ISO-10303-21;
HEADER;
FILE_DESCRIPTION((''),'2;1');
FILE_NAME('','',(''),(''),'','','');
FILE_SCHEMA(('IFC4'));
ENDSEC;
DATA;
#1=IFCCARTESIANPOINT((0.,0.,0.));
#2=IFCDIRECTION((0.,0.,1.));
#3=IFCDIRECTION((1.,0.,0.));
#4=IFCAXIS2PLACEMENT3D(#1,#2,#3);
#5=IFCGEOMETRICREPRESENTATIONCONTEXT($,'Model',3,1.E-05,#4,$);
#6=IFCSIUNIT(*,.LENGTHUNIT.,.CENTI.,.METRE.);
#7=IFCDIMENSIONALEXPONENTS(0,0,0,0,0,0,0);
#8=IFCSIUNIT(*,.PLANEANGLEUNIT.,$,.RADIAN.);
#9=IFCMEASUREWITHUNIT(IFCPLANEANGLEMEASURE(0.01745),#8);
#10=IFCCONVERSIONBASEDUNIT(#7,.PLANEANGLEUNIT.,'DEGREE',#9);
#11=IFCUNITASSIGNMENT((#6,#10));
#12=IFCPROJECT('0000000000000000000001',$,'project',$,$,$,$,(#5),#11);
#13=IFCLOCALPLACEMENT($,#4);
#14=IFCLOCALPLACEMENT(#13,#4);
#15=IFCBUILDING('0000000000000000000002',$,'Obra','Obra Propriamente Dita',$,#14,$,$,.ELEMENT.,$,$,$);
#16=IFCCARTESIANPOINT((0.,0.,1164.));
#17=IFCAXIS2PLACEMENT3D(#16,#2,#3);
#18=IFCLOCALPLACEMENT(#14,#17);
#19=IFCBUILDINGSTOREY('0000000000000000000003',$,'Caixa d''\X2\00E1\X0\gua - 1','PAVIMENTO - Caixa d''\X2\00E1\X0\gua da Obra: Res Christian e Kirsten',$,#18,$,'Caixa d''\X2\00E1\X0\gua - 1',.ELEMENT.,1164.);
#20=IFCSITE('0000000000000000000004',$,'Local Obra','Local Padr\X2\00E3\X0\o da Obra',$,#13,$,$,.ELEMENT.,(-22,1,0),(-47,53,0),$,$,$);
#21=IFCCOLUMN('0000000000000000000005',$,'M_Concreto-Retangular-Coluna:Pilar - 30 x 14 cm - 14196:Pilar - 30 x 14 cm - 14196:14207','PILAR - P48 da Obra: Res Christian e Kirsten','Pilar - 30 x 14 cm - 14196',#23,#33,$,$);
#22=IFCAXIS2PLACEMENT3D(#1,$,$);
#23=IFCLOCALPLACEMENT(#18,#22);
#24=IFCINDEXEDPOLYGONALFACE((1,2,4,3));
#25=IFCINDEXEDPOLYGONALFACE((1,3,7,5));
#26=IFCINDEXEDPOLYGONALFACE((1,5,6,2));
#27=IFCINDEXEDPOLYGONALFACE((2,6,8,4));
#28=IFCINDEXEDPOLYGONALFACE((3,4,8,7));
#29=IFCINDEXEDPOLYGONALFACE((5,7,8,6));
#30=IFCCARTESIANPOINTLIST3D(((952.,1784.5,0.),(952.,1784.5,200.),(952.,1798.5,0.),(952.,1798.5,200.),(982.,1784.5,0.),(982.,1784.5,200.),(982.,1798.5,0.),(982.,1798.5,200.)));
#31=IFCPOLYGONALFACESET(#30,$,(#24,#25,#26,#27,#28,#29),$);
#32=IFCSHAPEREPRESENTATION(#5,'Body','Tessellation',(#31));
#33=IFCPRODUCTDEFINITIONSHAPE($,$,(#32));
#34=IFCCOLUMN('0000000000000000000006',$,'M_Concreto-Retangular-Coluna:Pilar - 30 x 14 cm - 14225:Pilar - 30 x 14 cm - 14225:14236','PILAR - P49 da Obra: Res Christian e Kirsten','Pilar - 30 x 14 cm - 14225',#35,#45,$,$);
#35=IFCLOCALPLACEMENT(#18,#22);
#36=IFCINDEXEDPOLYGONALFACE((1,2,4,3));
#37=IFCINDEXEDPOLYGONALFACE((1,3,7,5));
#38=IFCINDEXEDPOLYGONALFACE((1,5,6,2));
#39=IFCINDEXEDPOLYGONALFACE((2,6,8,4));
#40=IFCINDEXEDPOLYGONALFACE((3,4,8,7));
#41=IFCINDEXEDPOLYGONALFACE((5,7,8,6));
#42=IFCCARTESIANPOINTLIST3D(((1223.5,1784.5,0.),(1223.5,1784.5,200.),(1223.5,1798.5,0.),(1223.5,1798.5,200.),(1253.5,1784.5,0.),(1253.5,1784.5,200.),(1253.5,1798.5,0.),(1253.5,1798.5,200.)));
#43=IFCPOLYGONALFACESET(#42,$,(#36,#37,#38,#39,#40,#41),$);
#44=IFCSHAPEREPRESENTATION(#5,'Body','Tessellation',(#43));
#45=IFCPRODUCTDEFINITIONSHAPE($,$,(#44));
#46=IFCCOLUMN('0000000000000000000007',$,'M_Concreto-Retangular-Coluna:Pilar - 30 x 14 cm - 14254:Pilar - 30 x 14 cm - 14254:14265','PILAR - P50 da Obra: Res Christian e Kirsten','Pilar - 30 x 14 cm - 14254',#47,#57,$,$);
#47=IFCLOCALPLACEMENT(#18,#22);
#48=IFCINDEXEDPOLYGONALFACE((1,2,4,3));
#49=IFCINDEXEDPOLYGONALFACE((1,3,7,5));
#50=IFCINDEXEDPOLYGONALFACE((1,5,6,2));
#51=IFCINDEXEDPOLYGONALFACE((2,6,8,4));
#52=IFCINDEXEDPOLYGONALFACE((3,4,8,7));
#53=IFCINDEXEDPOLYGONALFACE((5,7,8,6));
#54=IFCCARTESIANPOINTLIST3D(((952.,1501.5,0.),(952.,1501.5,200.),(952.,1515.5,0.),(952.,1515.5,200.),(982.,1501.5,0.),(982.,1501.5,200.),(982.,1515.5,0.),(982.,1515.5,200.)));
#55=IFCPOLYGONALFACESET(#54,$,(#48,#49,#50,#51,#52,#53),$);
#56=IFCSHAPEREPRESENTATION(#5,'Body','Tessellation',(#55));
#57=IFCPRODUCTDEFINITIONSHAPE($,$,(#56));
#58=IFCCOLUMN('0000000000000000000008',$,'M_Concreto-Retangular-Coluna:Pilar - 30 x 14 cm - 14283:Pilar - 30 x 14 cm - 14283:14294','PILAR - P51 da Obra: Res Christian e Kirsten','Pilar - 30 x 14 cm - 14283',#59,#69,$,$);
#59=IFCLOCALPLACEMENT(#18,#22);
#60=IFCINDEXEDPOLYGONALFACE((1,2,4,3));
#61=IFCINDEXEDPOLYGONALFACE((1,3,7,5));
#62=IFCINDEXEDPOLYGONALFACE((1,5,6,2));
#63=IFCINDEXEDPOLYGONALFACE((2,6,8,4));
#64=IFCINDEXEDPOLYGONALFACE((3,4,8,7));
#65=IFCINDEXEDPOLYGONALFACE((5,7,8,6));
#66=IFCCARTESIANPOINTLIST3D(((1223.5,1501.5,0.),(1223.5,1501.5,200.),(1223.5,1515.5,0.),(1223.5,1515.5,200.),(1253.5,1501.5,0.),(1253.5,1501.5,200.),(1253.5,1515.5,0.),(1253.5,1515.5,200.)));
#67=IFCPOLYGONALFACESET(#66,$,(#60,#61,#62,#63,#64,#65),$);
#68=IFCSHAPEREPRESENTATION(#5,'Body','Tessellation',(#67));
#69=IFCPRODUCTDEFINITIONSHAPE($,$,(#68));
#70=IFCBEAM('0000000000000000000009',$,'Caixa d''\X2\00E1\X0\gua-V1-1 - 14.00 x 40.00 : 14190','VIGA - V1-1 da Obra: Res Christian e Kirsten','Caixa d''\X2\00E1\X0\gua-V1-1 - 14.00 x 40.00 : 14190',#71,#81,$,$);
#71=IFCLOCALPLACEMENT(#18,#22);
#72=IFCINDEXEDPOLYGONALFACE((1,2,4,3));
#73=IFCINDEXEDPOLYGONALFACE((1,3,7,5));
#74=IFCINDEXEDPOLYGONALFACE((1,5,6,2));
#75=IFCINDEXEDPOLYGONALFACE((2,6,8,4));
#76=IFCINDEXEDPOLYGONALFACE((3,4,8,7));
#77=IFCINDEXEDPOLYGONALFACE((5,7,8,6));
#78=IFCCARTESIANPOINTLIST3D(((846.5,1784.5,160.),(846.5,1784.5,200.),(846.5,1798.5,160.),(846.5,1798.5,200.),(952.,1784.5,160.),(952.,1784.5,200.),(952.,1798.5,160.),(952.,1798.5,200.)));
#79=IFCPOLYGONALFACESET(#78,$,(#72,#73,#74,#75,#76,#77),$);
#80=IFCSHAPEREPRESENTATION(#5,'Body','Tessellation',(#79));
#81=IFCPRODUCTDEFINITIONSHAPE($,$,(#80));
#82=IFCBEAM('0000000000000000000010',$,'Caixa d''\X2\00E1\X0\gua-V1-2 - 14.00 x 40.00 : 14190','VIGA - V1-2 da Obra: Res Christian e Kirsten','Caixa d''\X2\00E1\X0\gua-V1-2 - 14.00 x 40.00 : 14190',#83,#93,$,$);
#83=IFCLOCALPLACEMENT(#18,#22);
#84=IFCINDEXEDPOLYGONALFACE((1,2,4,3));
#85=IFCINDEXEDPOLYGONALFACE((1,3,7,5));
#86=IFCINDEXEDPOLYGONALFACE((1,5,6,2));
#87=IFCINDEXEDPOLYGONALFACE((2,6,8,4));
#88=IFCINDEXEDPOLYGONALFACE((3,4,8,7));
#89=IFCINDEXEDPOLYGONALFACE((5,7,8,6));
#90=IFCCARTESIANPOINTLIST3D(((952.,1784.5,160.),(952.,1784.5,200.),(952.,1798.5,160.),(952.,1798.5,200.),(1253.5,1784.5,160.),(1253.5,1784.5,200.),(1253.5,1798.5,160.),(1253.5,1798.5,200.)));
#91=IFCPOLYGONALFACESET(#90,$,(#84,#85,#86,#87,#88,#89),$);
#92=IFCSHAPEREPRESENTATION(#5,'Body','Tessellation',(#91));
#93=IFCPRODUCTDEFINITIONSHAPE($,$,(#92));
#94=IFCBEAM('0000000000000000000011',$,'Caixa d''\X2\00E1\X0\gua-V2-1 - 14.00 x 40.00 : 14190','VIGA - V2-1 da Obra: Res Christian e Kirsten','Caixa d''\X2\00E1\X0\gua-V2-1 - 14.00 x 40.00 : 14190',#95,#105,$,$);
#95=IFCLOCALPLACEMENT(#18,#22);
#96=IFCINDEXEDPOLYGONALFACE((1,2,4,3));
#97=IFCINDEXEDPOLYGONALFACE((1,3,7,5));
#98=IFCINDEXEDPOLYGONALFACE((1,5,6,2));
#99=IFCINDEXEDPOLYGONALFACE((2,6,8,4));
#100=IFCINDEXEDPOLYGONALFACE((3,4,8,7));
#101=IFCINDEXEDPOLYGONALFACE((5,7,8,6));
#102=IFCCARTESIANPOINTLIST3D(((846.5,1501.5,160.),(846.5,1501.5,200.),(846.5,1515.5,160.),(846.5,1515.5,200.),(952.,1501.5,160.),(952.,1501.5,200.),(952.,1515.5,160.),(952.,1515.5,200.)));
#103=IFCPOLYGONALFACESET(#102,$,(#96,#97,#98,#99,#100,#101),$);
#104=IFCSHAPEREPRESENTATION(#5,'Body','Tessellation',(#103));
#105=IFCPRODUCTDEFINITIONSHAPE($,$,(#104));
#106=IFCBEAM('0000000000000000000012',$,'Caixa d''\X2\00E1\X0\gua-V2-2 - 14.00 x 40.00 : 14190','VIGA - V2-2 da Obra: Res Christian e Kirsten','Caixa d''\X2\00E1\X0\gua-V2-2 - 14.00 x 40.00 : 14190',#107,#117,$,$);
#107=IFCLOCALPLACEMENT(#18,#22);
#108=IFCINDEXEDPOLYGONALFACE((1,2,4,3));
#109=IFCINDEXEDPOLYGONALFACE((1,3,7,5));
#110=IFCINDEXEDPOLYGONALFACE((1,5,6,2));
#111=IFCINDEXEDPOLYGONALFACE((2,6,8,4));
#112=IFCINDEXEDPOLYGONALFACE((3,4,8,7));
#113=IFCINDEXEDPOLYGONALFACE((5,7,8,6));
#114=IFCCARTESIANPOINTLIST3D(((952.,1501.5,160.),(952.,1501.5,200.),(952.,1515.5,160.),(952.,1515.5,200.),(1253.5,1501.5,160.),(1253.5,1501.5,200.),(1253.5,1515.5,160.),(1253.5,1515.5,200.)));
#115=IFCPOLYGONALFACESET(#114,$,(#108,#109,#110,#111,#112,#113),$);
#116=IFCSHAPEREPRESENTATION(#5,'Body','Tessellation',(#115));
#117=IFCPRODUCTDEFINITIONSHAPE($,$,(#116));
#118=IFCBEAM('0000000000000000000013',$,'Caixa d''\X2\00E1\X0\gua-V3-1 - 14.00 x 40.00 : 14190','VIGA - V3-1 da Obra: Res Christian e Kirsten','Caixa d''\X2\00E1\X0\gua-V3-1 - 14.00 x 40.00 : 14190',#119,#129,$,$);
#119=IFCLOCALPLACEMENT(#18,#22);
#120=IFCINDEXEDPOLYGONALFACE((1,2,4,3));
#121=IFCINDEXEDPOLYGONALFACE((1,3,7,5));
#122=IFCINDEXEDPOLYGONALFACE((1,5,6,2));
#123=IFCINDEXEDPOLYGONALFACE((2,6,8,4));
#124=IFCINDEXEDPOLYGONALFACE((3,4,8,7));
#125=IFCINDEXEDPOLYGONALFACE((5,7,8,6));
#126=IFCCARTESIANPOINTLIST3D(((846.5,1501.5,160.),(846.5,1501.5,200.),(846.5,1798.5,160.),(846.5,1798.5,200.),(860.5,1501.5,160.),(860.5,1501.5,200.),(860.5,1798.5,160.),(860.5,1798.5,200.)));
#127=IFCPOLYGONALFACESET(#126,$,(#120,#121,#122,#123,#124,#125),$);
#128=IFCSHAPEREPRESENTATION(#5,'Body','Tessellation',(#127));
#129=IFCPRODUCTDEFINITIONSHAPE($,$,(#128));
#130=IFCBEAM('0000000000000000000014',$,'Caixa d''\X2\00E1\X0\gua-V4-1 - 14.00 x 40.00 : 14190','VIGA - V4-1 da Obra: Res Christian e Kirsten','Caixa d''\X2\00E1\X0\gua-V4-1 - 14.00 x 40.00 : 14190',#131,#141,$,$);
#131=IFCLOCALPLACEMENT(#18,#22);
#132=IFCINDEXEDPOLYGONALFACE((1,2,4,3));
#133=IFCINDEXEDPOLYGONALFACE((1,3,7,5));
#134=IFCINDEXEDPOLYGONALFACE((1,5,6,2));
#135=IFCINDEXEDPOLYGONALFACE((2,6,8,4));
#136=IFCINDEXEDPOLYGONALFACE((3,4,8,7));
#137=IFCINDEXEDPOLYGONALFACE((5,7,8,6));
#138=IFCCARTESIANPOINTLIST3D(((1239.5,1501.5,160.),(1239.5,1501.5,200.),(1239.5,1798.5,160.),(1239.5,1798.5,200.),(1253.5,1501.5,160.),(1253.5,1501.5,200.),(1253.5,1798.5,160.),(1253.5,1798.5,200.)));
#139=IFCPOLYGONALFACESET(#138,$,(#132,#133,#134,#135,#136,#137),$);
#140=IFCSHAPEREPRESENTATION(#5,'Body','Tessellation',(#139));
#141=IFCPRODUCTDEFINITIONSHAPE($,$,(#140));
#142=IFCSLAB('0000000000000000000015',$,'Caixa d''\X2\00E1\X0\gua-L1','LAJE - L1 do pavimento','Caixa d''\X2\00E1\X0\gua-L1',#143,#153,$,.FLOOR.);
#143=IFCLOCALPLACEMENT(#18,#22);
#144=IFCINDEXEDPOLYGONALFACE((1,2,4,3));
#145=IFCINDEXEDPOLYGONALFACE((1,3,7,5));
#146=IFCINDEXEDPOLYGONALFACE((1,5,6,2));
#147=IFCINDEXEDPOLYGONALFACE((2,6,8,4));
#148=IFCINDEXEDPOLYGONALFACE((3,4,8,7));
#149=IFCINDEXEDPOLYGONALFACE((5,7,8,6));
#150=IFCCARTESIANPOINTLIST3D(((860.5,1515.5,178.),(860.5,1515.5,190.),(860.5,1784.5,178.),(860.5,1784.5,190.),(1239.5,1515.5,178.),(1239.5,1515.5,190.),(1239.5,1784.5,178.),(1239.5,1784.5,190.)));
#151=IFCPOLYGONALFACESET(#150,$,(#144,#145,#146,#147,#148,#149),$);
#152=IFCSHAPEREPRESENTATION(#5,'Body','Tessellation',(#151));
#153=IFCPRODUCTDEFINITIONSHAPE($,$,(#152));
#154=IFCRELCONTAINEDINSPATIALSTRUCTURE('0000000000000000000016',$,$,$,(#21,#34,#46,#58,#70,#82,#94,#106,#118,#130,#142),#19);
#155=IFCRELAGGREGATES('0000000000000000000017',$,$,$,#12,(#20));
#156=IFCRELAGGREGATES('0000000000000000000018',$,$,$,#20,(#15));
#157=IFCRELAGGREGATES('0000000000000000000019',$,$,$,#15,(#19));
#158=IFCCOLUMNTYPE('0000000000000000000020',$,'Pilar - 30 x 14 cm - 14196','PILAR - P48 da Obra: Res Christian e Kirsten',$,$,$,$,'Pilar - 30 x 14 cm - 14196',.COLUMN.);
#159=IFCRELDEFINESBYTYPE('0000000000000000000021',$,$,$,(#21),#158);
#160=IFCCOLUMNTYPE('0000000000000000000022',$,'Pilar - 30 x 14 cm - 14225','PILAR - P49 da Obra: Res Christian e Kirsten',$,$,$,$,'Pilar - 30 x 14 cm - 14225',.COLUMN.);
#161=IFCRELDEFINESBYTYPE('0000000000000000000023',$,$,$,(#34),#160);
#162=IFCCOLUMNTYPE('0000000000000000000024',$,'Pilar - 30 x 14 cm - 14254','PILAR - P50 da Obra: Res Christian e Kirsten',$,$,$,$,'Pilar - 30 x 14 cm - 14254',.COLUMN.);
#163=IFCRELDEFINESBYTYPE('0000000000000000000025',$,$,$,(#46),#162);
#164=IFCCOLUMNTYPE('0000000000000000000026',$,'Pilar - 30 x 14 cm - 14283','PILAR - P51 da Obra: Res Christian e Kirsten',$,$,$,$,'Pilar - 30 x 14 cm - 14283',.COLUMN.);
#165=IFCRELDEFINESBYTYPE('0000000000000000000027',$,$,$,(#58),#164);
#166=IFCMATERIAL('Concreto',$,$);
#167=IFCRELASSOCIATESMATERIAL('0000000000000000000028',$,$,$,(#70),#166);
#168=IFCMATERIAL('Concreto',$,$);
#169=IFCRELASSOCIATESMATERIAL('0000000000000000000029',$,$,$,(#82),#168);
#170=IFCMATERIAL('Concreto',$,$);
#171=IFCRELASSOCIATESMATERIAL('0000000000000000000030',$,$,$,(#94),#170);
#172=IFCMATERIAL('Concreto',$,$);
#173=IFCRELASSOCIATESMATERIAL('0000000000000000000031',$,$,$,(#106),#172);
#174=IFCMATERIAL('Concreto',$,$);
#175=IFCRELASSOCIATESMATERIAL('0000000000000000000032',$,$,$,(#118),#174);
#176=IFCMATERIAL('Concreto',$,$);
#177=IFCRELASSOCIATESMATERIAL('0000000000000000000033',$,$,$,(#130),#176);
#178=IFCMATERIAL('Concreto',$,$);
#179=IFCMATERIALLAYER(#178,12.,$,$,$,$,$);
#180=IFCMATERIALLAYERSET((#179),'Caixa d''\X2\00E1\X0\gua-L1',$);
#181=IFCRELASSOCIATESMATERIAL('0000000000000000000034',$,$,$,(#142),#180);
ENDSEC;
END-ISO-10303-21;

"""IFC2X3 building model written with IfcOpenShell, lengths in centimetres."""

from ifc_helpers import new_model, entity, si_unit, converted_unit, frame, origin, origin_with_axes, origin_2d_with_axis, place, context, project, spatial, polyline, rectangle, outline, extrude, source, transform, mapped, material, layer, layer_set, layer_usage, type_object, type_shapes, element, save


model = new_model("IFC2X3")

# Units and contexts
model_context = context("Model", 3, precision=1e-05, world=origin_with_axes())
ifc_project = project(units=[si_unit("LENGTHUNIT", "METRE", prefix="CENTI"), converted_unit("PLANEANGLEUNIT", "DEGREE", entity("IfcPlaneAngleMeasure", 0.01745), si_unit("PLANEANGLEUNIT", "RADIAN"), dimensions=[0, 0, 0, 0, 0, 0, 0])], contexts=[model_context])

# Site, building, storey
site_placement = place(None, origin_with_axes())
site = spatial("IfcSite", under=ifc_project, at=site_placement, Name="Local Obra", Description="Local Padrão da Obra", CompositionType="ELEMENT", RefLatitude=(-22, 1, 0), RefLongitude=(-47, 53, 0))
building_placement = place(site_placement, origin_with_axes())
building = spatial("IfcBuilding", under=site, at=building_placement, Name="Obra", Description="Obra Propriamente Dita", CompositionType="ELEMENT")
storey_placement = place(building_placement, frame((0.0, 0.0, 1164.0), z_axis=(0.0, 0.0, 1.0), x_axis=(1.0, 0.0, 0.0)))
storey = spatial("IfcBuildingStorey", under=building, at=storey_placement, Name="Caixa d'água - 1", Description="PAVIMENTO - Caixa d'água da Obra: Res Christian e Kirsten", LongName="Caixa d'água - 1", CompositionType="ELEMENT", Elevation=1164.0)

# Columns
column_type_1 = type_object("IfcColumnType", Name="Pilar - 30 x 14 cm - 14196", Description="PILAR - P48 da Obra: Res Christian e Kirsten", ElementType="Pilar - 30 x 14 cm - 14196", PredefinedType="COLUMN")
shared_shape_1 = source(origin(), model_context, "Body", "SweptSolid", [
    extrude(rectangle(XDim=30.0, YDim=14.0, at=origin_2d_with_axis()), origin(), (0.0, 0.0, 1.0), 200.0),
])
type_shapes(column_type_1, [shared_shape_1])
column_1_placement = place(storey_placement, frame((967.0, 1791.5, 0.0), z_axis=(0.0, 0.0, 1.0), x_axis=(1.0, 0.0, 0.0)))
element("IfcColumn", 1, at=column_1_placement, inside=storey, type_object=column_type_1, Name="M_Concreto-Retangular-Coluna:Pilar - 30 x 14 cm - 14196:Pilar - 30 x 14 cm - 14196:14207", Description="PILAR - P48 da Obra: Res Christian e Kirsten", ObjectType="Pilar - 30 x 14 cm - 14196", context=model_context, shape_type="MappedRepresentation", body=[
    mapped(shared_shape_1, transform((0.0, 0.0, 0.0), scale=1.0)),
])
column_type_2 = type_object("IfcColumnType", Name="Pilar - 30 x 14 cm - 14225", Description="PILAR - P49 da Obra: Res Christian e Kirsten", ElementType="Pilar - 30 x 14 cm - 14225", PredefinedType="COLUMN")
shared_shape_2 = source(origin(), model_context, "Body", "SweptSolid", [
    extrude(rectangle(XDim=30.0, YDim=14.0, at=origin_2d_with_axis()), origin(), (0.0, 0.0, 1.0), 200.0),
])
type_shapes(column_type_2, [shared_shape_2])
column_2_placement = place(storey_placement, frame((1238.5, 1791.5, 0.0), z_axis=(0.0, 0.0, 1.0), x_axis=(1.0, 0.0, 0.0)))
element("IfcColumn", 2, at=column_2_placement, inside=storey, type_object=column_type_2, Name="M_Concreto-Retangular-Coluna:Pilar - 30 x 14 cm - 14225:Pilar - 30 x 14 cm - 14225:14236", Description="PILAR - P49 da Obra: Res Christian e Kirsten", ObjectType="Pilar - 30 x 14 cm - 14225", context=model_context, shape_type="MappedRepresentation", body=[
    mapped(shared_shape_2, transform((0.0, 0.0, 0.0), scale=1.0)),
])
column_type_3 = type_object("IfcColumnType", Name="Pilar - 30 x 14 cm - 14254", Description="PILAR - P50 da Obra: Res Christian e Kirsten", ElementType="Pilar - 30 x 14 cm - 14254", PredefinedType="COLUMN")
shared_shape_3 = source(origin(), model_context, "Body", "SweptSolid", [
    extrude(rectangle(XDim=30.0, YDim=14.0, at=origin_2d_with_axis()), origin(), (0.0, 0.0, 1.0), 200.0),
])
type_shapes(column_type_3, [shared_shape_3])
column_3_placement = place(storey_placement, frame((967.0, 1508.5, 0.0), z_axis=(0.0, 0.0, 1.0), x_axis=(1.0, 0.0, 0.0)))
element("IfcColumn", 3, at=column_3_placement, inside=storey, type_object=column_type_3, Name="M_Concreto-Retangular-Coluna:Pilar - 30 x 14 cm - 14254:Pilar - 30 x 14 cm - 14254:14265", Description="PILAR - P50 da Obra: Res Christian e Kirsten", ObjectType="Pilar - 30 x 14 cm - 14254", context=model_context, shape_type="MappedRepresentation", body=[
    mapped(shared_shape_3, transform((0.0, 0.0, 0.0), scale=1.0)),
])
column_type_4 = type_object("IfcColumnType", Name="Pilar - 30 x 14 cm - 14283", Description="PILAR - P51 da Obra: Res Christian e Kirsten", ElementType="Pilar - 30 x 14 cm - 14283", PredefinedType="COLUMN")
shared_shape_4 = source(origin(), model_context, "Body", "SweptSolid", [
    extrude(rectangle(XDim=30.0, YDim=14.0, at=origin_2d_with_axis()), origin(), (0.0, 0.0, 1.0), 200.0),
])
type_shapes(column_type_4, [shared_shape_4])
column_4_placement = place(storey_placement, frame((1238.5, 1508.5, 0.0), z_axis=(0.0, 0.0, 1.0), x_axis=(1.0, 0.0, 0.0)))
element("IfcColumn", 4, at=column_4_placement, inside=storey, type_object=column_type_4, Name="M_Concreto-Retangular-Coluna:Pilar - 30 x 14 cm - 14283:Pilar - 30 x 14 cm - 14283:14294", Description="PILAR - P51 da Obra: Res Christian e Kirsten", ObjectType="Pilar - 30 x 14 cm - 14283", context=model_context, shape_type="MappedRepresentation", body=[
    mapped(shared_shape_4, transform((0.0, 0.0, 0.0), scale=1.0)),
])

# Beams
ifc_material_1 = material(Name="Concreto")
beam_1_placement = place(storey_placement, frame((846.5, 1798.5, 200.0), z_axis=(1.0, 0.0, 0.0), x_axis=(0.0, -1.0, 0.0)))
element("IfcBeam", 5, at=beam_1_placement, inside=storey, material=ifc_material_1, Name="Caixa d'água-V1-1 - 14.00 x 40.00 : 14190", Description="VIGA - V1-1 da Obra: Res Christian e Kirsten", ObjectType="Caixa d'água-V1-1 - 14.00 x 40.00 : 14190", context=model_context, shape_type="SweptSolid", body=[
    extrude(outline(polyline([(0.0, 0.0), (14.0, 0.0), (14.0, 40.0), (0.0, 40.0), (0.0, 0.0)])), origin_with_axes(), (0.0, 0.0, 1.0), 105.5),
])
ifc_material_2 = material(Name="Concreto")
beam_2_placement = place(storey_placement, frame((952.0, 1798.5, 200.0), z_axis=(1.0, 0.0, 0.0), x_axis=(0.0, -1.0, 0.0)))
element("IfcBeam", 6, at=beam_2_placement, inside=storey, material=ifc_material_2, Name="Caixa d'água-V1-2 - 14.00 x 40.00 : 14190", Description="VIGA - V1-2 da Obra: Res Christian e Kirsten", ObjectType="Caixa d'água-V1-2 - 14.00 x 40.00 : 14190", context=model_context, shape_type="SweptSolid", body=[
    extrude(outline(polyline([(0.0, 0.0), (14.0, 0.0), (14.0, 40.0), (0.0, 40.0), (0.0, 0.0)])), origin_with_axes(), (0.0, 0.0, 1.0), 301.5),
])
ifc_material_3 = material(Name="Concreto")
beam_3_placement = place(storey_placement, frame((846.5, 1501.5, 200.0), z_axis=(1.0, 0.0, 0.0), x_axis=(0.0, -1.0, 0.0)))
element("IfcBeam", 7, at=beam_3_placement, inside=storey, material=ifc_material_3, Name="Caixa d'água-V2-1 - 14.00 x 40.00 : 14190", Description="VIGA - V2-1 da Obra: Res Christian e Kirsten", ObjectType="Caixa d'água-V2-1 - 14.00 x 40.00 : 14190", context=model_context, shape_type="SweptSolid", body=[
    extrude(outline(polyline([(-14.0, 0.0), (0.0, 0.0), (0.0, 40.0), (-14.0, 40.0), (-14.0, 0.0)])), origin_with_axes(), (0.0, 0.0, 1.0), 105.5),
])
ifc_material_4 = material(Name="Concreto")
beam_4_placement = place(storey_placement, frame((952.0, 1501.5, 200.0), z_axis=(1.0, 0.0, 0.0), x_axis=(0.0, -1.0, 0.0)))
element("IfcBeam", 8, at=beam_4_placement, inside=storey, material=ifc_material_4, Name="Caixa d'água-V2-2 - 14.00 x 40.00 : 14190", Description="VIGA - V2-2 da Obra: Res Christian e Kirsten", ObjectType="Caixa d'água-V2-2 - 14.00 x 40.00 : 14190", context=model_context, shape_type="SweptSolid", body=[
    extrude(outline(polyline([(-14.0, 0.0), (0.0, 0.0), (0.0, 40.0), (-14.0, 40.0), (-14.0, 0.0)])), origin_with_axes(), (0.0, 0.0, 1.0), 301.5),
])
ifc_material_5 = material(Name="Concreto")
beam_5_placement = place(storey_placement, frame((846.5, 1501.5, 200.0), z_axis=(0.0, 1.0, 0.0), x_axis=(1.0, 0.0, 0.0)))
element("IfcBeam", 9, at=beam_5_placement, inside=storey, material=ifc_material_5, Name="Caixa d'água-V3-1 - 14.00 x 40.00 : 14190", Description="VIGA - V3-1 da Obra: Res Christian e Kirsten", ObjectType="Caixa d'água-V3-1 - 14.00 x 40.00 : 14190", context=model_context, shape_type="SweptSolid", body=[
    extrude(outline(polyline([(0.0, 0.0), (14.0, 0.0), (14.0, 40.0), (0.0, 40.0), (0.0, 0.0)])), origin_with_axes(), (0.0, 0.0, 1.0), 297.0),
])
ifc_material_6 = material(Name="Concreto")
beam_6_placement = place(storey_placement, frame((1253.5, 1501.5, 200.0), z_axis=(0.0, 1.0, 0.0), x_axis=(1.0, 0.0, 0.0)))
element("IfcBeam", 10, at=beam_6_placement, inside=storey, material=ifc_material_6, Name="Caixa d'água-V4-1 - 14.00 x 40.00 : 14190", Description="VIGA - V4-1 da Obra: Res Christian e Kirsten", ObjectType="Caixa d'água-V4-1 - 14.00 x 40.00 : 14190", context=model_context, shape_type="SweptSolid", body=[
    extrude(outline(polyline([(-14.0, 0.0), (0.0, 0.0), (0.0, 40.0), (-14.0, 40.0), (-14.0, 0.0)])), origin_with_axes(), (0.0, 0.0, 1.0), 297.0),
])

# Slab
ifc_material_7 = material(Name="Concreto")
ifc_layer = layer(ifc_material_7, 12.0)
ifc_layer_set = layer_set([ifc_layer], Name="Caixa d'água-L1")
ifc_layer_usage = layer_usage(ifc_layer_set, "AXIS3", "POSITIVE", 0.0)
slab_placement = place(storey_placement, frame((1239.5, 1515.5, 178.0), z_axis=(0.0, 0.0, 1.0), x_axis=(1.0, 0.0, 0.0)))
element("IfcSlab", 11, at=slab_placement, inside=storey, material=ifc_layer_usage, Name="Caixa d'água-L1", Description="LAJE - L1 do pavimento", ObjectType="Caixa d'água-L1", PredefinedType="FLOOR", context=model_context, shape_type="SweptSolid", body=[
    extrude(outline(polyline([(0.0, 269.0), (-379.0, 269.0), (-379.0, 0.0), (0.0, 0.0), (0.0, 269.0)])), origin_with_axes(), (0.0, 0.0, 1.0), 12.0),
])

save(model, "model.ifc")
